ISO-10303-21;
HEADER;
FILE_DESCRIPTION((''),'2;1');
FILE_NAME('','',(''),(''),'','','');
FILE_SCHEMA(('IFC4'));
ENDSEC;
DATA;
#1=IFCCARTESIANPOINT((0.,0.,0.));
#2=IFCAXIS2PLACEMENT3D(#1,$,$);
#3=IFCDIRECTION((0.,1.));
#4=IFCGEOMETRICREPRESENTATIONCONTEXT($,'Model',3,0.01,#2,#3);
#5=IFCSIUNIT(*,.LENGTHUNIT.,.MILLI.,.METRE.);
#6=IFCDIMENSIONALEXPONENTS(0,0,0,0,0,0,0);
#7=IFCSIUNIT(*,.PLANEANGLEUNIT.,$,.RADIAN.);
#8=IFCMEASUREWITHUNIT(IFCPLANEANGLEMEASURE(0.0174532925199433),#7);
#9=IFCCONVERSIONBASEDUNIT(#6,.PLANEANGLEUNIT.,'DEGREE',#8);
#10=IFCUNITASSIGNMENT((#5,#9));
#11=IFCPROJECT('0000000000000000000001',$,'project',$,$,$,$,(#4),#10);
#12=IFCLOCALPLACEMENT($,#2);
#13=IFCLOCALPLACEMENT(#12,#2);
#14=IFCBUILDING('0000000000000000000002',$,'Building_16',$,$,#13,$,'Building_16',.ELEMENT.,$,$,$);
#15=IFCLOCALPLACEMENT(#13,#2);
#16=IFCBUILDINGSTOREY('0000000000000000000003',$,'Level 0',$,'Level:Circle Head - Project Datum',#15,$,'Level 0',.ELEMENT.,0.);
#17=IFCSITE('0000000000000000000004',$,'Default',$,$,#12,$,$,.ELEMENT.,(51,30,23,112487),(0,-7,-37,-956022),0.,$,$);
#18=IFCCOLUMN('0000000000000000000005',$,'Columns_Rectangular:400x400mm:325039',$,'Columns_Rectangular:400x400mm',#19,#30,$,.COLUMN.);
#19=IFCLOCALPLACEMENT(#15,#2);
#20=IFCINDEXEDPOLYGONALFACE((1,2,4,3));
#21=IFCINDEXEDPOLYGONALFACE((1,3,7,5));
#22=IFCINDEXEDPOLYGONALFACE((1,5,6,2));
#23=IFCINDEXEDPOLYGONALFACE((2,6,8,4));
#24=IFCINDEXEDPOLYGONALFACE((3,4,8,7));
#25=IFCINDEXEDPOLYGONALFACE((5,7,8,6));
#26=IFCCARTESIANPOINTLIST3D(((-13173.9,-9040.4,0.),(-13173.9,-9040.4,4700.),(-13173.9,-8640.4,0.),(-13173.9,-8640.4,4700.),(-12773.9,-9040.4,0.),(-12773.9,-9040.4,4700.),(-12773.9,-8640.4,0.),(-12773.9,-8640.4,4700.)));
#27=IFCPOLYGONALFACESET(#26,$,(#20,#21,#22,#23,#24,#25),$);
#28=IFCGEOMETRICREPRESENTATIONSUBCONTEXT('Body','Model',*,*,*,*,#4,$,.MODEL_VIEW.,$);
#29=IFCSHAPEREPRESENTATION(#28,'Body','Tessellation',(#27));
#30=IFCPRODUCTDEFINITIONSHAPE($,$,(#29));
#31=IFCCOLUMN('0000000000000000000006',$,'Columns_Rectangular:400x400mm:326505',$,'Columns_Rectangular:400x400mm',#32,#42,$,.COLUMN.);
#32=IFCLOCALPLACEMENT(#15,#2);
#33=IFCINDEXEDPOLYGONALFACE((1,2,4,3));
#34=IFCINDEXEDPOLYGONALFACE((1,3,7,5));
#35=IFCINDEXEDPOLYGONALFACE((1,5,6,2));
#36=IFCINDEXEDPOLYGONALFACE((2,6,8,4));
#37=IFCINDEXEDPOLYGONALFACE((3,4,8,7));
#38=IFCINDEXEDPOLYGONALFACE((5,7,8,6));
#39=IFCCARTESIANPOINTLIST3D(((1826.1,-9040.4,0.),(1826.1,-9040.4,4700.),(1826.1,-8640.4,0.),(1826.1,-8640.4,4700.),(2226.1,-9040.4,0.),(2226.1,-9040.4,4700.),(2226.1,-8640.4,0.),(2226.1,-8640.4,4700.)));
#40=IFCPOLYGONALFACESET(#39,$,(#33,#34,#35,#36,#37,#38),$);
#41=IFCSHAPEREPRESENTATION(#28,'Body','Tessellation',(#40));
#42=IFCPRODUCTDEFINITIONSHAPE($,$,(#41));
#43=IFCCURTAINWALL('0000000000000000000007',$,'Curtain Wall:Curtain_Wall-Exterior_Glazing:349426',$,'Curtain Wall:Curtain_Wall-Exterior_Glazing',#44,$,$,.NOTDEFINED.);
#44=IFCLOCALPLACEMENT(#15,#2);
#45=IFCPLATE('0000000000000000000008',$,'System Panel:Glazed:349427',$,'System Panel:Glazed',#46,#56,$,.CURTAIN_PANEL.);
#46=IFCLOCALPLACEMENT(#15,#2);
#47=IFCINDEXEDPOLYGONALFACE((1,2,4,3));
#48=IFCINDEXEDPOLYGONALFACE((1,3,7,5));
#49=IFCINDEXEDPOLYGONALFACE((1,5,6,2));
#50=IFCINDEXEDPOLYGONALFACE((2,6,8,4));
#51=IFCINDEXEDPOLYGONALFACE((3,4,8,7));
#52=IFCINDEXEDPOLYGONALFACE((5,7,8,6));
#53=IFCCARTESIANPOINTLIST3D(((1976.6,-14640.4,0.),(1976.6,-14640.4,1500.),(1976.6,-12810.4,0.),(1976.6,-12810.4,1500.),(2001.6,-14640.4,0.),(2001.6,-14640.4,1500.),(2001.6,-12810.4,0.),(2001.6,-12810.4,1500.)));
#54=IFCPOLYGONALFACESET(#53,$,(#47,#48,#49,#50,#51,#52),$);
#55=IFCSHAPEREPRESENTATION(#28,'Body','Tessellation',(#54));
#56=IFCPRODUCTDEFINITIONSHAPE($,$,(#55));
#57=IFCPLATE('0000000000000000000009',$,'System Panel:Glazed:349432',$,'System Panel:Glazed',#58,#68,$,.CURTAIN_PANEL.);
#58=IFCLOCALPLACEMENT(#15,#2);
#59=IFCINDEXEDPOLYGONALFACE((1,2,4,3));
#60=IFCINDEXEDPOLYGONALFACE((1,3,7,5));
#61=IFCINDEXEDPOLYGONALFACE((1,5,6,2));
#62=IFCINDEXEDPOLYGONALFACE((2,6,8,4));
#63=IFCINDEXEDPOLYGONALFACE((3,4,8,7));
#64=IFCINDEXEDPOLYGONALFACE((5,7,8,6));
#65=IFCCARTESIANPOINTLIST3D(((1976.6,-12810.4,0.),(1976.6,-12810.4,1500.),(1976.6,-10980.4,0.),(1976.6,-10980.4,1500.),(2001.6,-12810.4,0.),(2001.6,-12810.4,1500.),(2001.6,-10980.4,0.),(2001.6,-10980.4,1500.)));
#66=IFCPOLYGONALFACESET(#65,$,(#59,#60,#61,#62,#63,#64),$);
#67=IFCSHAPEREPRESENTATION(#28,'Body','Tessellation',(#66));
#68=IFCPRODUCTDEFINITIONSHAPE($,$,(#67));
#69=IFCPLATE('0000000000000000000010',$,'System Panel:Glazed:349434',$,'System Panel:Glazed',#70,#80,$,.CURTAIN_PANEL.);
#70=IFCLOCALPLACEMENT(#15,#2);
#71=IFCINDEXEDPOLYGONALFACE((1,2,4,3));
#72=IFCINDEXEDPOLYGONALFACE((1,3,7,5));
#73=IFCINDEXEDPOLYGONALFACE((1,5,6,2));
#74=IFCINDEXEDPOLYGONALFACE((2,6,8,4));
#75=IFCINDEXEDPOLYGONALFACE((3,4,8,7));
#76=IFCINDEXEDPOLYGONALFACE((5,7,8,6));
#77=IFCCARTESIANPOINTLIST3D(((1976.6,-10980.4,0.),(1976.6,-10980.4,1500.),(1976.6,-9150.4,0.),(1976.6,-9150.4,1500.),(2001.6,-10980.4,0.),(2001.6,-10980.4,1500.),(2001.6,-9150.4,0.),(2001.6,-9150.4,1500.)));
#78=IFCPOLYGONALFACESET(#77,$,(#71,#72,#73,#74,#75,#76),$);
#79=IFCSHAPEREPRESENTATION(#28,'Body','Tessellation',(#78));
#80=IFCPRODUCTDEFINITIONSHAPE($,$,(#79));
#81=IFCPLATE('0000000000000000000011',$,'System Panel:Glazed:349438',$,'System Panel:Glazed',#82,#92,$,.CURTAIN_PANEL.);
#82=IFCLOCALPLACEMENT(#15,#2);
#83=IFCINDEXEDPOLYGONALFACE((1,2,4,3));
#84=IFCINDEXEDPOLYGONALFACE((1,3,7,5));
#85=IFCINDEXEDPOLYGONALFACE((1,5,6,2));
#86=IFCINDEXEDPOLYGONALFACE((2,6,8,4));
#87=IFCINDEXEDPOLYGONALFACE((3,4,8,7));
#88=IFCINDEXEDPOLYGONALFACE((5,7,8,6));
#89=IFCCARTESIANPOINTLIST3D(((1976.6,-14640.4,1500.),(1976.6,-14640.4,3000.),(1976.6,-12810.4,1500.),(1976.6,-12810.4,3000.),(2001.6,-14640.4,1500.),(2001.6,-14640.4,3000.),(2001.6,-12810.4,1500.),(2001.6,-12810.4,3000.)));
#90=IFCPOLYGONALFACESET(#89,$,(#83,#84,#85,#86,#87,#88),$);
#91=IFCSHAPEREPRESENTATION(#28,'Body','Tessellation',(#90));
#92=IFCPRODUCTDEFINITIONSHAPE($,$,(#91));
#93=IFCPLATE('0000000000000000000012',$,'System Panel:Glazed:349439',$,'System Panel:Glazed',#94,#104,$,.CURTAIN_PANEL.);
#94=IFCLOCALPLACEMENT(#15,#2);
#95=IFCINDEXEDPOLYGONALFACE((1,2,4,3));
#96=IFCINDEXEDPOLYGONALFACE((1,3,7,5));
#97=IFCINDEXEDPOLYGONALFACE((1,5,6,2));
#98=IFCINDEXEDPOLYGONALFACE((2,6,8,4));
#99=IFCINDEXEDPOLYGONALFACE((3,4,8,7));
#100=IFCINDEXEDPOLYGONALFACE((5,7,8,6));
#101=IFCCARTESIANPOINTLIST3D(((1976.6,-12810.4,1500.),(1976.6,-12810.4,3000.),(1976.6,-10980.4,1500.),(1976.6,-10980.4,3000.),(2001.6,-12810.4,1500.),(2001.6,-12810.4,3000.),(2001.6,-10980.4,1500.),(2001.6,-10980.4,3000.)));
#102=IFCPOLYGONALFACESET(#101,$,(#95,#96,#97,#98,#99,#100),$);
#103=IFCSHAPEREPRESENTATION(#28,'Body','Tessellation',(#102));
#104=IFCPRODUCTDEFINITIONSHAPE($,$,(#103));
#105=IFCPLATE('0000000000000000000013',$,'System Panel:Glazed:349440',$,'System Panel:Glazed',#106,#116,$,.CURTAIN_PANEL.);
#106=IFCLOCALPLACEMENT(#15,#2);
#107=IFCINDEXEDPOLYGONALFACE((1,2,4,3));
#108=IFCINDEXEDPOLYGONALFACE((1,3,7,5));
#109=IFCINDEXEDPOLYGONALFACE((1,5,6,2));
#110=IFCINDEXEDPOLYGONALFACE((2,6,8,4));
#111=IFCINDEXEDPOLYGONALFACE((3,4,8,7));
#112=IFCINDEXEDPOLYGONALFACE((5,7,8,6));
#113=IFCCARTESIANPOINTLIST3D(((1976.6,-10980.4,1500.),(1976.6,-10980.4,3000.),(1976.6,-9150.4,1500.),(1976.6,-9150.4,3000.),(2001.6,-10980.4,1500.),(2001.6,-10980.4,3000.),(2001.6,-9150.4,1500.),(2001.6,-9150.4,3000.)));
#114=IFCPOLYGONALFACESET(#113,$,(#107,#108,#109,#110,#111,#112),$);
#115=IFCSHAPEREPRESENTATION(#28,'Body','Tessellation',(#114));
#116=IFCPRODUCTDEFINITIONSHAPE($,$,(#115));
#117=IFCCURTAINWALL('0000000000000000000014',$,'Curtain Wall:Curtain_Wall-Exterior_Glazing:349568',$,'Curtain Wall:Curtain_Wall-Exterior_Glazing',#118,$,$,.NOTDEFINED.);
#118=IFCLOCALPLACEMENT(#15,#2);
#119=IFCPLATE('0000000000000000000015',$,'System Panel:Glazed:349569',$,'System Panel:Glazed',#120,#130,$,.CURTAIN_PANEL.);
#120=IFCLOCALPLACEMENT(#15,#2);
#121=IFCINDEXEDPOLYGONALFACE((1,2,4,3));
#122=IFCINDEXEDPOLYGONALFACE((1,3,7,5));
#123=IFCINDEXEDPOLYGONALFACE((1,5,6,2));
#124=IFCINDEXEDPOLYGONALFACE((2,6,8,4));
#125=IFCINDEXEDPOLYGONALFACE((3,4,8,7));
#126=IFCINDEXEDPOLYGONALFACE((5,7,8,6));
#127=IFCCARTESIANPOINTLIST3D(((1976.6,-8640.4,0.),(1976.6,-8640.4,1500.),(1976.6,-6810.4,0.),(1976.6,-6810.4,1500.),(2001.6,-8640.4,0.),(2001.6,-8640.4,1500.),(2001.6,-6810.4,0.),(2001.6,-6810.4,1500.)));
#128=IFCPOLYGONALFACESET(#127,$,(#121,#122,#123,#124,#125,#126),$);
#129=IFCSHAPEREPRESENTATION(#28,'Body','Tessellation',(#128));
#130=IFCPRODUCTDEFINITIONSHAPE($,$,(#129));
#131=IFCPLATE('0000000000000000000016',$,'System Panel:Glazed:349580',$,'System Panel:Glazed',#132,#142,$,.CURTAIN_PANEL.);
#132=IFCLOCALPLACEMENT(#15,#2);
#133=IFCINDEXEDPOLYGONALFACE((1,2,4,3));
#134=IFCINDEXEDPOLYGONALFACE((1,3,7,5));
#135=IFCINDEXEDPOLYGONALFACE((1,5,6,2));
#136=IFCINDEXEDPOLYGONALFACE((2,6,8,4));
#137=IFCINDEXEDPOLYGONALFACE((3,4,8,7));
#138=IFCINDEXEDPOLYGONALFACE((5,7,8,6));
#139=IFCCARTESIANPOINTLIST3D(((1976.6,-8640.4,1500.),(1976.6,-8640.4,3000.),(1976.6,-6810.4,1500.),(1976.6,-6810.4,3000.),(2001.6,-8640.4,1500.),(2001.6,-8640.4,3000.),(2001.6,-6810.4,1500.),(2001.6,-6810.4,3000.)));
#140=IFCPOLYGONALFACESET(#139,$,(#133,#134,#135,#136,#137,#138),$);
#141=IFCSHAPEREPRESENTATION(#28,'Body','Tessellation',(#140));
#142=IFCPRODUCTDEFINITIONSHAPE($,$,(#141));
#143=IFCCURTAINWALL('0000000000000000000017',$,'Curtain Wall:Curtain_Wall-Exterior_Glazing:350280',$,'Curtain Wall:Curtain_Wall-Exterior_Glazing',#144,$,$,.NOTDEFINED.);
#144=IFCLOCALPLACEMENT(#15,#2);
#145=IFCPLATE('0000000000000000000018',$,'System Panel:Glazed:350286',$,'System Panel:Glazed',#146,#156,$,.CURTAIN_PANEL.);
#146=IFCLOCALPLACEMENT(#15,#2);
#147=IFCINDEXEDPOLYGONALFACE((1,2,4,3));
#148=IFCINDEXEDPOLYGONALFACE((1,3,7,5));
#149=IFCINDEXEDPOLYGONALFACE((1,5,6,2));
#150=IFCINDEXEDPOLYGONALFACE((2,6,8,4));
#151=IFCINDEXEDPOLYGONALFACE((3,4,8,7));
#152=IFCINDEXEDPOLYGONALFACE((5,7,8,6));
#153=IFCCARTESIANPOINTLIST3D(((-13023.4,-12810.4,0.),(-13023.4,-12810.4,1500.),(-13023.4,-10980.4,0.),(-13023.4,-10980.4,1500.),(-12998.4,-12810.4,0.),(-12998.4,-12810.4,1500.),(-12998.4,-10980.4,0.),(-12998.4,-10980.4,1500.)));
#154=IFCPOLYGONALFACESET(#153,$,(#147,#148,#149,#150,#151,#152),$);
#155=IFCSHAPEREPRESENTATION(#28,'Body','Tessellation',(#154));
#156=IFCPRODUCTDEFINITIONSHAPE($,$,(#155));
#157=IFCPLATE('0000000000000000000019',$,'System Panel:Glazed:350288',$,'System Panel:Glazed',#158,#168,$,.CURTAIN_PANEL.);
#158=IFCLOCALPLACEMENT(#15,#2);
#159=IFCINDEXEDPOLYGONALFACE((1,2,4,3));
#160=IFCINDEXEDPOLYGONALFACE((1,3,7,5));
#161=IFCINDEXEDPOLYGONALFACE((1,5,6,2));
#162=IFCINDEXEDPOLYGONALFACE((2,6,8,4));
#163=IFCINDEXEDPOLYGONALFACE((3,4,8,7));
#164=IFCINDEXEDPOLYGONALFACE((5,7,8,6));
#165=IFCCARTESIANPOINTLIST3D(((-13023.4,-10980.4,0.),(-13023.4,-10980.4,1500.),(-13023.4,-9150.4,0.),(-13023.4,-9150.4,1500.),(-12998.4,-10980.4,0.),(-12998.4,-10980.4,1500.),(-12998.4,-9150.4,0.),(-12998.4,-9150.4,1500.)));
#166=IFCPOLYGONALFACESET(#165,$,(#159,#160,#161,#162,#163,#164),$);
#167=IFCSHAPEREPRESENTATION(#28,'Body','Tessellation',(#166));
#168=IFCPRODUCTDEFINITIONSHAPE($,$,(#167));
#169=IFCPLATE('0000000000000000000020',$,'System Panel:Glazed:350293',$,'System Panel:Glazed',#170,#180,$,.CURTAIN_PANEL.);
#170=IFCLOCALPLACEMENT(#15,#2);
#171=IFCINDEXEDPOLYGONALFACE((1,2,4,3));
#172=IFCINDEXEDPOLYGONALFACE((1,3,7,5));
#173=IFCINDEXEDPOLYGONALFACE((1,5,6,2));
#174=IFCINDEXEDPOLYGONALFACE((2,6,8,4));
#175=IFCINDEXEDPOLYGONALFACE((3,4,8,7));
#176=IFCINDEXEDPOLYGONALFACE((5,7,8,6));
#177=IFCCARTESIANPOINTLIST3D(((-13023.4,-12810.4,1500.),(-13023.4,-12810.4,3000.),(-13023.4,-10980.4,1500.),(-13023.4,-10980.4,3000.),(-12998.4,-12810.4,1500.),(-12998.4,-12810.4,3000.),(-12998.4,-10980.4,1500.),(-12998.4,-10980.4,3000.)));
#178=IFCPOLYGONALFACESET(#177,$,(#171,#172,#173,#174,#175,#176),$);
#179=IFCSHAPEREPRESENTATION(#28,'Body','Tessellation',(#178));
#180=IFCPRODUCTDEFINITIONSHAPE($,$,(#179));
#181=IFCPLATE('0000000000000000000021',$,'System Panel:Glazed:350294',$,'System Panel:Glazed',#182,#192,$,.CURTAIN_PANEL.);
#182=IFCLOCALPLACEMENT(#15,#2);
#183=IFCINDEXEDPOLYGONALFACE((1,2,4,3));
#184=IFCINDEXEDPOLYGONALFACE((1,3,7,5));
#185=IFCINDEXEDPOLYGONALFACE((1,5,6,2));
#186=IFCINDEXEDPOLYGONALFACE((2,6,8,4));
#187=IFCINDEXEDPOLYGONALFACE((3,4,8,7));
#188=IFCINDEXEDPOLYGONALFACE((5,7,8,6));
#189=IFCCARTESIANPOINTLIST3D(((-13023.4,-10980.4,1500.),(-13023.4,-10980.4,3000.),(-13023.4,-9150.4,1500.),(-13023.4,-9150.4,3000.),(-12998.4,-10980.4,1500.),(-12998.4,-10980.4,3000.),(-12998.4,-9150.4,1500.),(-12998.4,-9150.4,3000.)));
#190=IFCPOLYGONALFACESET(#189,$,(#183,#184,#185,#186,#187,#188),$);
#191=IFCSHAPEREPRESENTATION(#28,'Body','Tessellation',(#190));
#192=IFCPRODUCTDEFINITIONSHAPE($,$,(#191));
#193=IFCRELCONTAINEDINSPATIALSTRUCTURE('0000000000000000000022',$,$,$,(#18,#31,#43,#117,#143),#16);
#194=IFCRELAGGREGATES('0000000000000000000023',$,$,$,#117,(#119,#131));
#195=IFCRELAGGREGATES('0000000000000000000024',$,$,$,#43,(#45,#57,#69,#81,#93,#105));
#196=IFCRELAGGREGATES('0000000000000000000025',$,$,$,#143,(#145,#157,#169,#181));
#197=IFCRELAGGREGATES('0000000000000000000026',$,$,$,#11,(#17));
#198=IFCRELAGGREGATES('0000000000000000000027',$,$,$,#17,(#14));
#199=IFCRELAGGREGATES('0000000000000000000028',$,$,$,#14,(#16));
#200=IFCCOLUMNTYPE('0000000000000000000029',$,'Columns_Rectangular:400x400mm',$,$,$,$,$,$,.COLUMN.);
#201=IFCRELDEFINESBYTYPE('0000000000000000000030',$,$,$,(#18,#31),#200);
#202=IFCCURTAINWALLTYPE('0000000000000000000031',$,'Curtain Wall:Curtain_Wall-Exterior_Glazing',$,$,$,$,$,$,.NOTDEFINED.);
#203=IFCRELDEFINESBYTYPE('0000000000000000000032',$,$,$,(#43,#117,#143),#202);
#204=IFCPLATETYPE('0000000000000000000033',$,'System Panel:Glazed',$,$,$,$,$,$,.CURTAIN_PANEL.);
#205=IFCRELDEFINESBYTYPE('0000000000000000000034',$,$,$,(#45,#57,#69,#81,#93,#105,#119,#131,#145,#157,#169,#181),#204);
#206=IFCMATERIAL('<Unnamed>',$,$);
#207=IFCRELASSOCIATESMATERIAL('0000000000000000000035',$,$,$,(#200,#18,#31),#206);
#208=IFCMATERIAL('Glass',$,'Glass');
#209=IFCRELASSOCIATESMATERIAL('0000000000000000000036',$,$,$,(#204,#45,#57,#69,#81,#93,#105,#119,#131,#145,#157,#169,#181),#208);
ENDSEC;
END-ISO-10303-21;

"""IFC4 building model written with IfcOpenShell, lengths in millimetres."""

from ifc_helpers import new_model, entity, si_unit, converted_unit, direction, frame, origin, place, context, subcontext, project, spatial, indexed_curve, outline, extrude, source, transform, mapped, material, type_object, type_shapes, element, aggregate, save


model = new_model("IFC4")

# Units and contexts
model_context = context("Model", 3, precision=0.01, world=origin(), true_north=direction((0.0, 1.0)))
body_context = subcontext(model_context, "Body", "Model", "MODEL_VIEW")
ifc_project = project(units=[si_unit("LENGTHUNIT", "METRE", prefix="MILLI"), converted_unit("PLANEANGLEUNIT", "DEGREE", entity("IfcPlaneAngleMeasure", 0.0174532925199433), si_unit("PLANEANGLEUNIT", "RADIAN"), dimensions=[0, 0, 0, 0, 0, 0, 0])], contexts=[model_context])

# Site, building, storey
site_placement = place(None, origin())
site = spatial("IfcSite", under=ifc_project, at=site_placement, Name="Default", CompositionType="ELEMENT", RefLatitude=(51, 30, 23, 112487), RefLongitude=(0, -7, -37, -956022), RefElevation=0.0)
building_placement = place(site_placement, origin())
building = spatial("IfcBuilding", under=site, at=building_placement, Name="Building_16", LongName="Building_16", CompositionType="ELEMENT")
storey_placement = place(building_placement, origin())
storey = spatial("IfcBuildingStorey", under=building, at=storey_placement, Name="Level 0", ObjectType="Level:Circle Head - Project Datum", LongName="Level 0", CompositionType="ELEMENT", Elevation=0.0)

# Columns
ifc_material_1 = material(Name="<Unnamed>")
column_type = type_object("IfcColumnType", Name="Columns_Rectangular:400x400mm", PredefinedType="COLUMN", material=ifc_material_1)
shared_shape_1 = source(origin(), body_context, "Body", "SweptSolid", [
    extrude(outline(indexed_curve([(-200.0, -200.0), (200.0, -200.0), (200.0, 200.0), (-200.0, 200.0), (-200.0, -200.0)], self_intersect=False)), frame((0.0, 0.0, 0.0), z_axis=(0.0, 0.0, 1.0), x_axis=(-1.0, 0.0, 0.0)), (0.0, 0.0, 1.0), 4700.0),
])
type_shapes(column_type, [shared_shape_1])
for number, where, name in (
    (1, (-12973.9, -8840.4, 0.0), "Columns_Rectangular:400x400mm:325039"),
    (2, (2026.1, -8840.4, 0.0), "Columns_Rectangular:400x400mm:326505"),
):
    element("IfcColumn", number, at=place(storey_placement, frame(where)), inside=storey, type_object=column_type, material=ifc_material_1, Name=name, ObjectType="Columns_Rectangular:400x400mm", PredefinedType="COLUMN", context=body_context, shape_type="MappedRepresentation", body=[
        mapped(shared_shape_1, transform((0.0, 0.0, 0.0), scale=1.0)),
    ])

# Curtain walls, plates
curtain_wall_type = type_object("IfcCurtainWallType", Name="Curtain Wall:Curtain_Wall-Exterior_Glazing", PredefinedType="NOTDEFINED")
curtain_wall_1_placement = place(storey_placement, origin())
curtain_wall_1 = element("IfcCurtainWall", 3, at=curtain_wall_1_placement, inside=storey, type_object=curtain_wall_type, Name="Curtain Wall:Curtain_Wall-Exterior_Glazing:349426", ObjectType="Curtain Wall:Curtain_Wall-Exterior_Glazing", PredefinedType="NOTDEFINED")
ifc_material_2 = material(Name="Glass", Category="Glass")
plate_type_1 = type_object("IfcPlateType", Name="System Panel:Glazed", PredefinedType="CURTAIN_PANEL", material=ifc_material_2)
shared_shape_2 = source(origin(), body_context, "Body", "SweptSolid", [
    extrude(outline(indexed_curve([(-12.5, -915.0), (12.5, -915.0), (12.5, 915.0), (-12.5, 915.0), (-12.5, -915.0)], self_intersect=False)), frame((0.0, 37.0, 0.0), z_axis=(0.0, 0.0, 1.0), x_axis=(0.0, 1.0, 0.0)), (0.0, 0.0, 1.0), 1500.0),
])
type_shapes(plate_type_1, [shared_shape_2])
plate_1_placement = place(curtain_wall_1_placement, frame((2026.1, -13725.4, 0.0), z_axis=(0.0, 0.0, 1.0), x_axis=(0.0, 1.0, 0.0)))
plate_1 = element("IfcPlate", 4, at=plate_1_placement, type_object=plate_type_1, material=ifc_material_2, Name="System Panel:Glazed:349427", ObjectType="System Panel:Glazed", PredefinedType="CURTAIN_PANEL", context=body_context, shape_type="MappedRepresentation", body=[
    mapped(shared_shape_2, transform((0.0, 0.0, 0.0), scale=1.0)),
])
plate_2_placement = place(curtain_wall_1_placement, frame((2026.1, -11895.4, 0.0), z_axis=(0.0, 0.0, 1.0), x_axis=(0.0, 1.0, 0.0)))
plate_2 = element("IfcPlate", 5, at=plate_2_placement, type_object=plate_type_1, material=ifc_material_2, Name="System Panel:Glazed:349432", ObjectType="System Panel:Glazed", PredefinedType="CURTAIN_PANEL", context=body_context, shape_type="MappedRepresentation", body=[
    mapped(shared_shape_2, transform((0.0, 0.0, 0.0), scale=1.0)),
])
plate_3_placement = place(curtain_wall_1_placement, frame((2026.1, -10065.4, 0.0), z_axis=(0.0, 0.0, 1.0), x_axis=(0.0, 1.0, 0.0)))
plate_3 = element("IfcPlate", 6, at=plate_3_placement, type_object=plate_type_1, material=ifc_material_2, Name="System Panel:Glazed:349434", ObjectType="System Panel:Glazed", PredefinedType="CURTAIN_PANEL", context=body_context, shape_type="MappedRepresentation", body=[
    mapped(shared_shape_2, transform((0.0, 0.0, 0.0), scale=1.0)),
])
plate_4_placement = place(curtain_wall_1_placement, frame((2026.1, -13725.4, 1500.0), z_axis=(0.0, 0.0, 1.0), x_axis=(0.0, 1.0, 0.0)))
plate_4 = element("IfcPlate", 7, at=plate_4_placement, type_object=plate_type_1, material=ifc_material_2, Name="System Panel:Glazed:349438", ObjectType="System Panel:Glazed", PredefinedType="CURTAIN_PANEL", context=body_context, shape_type="MappedRepresentation", body=[
    mapped(shared_shape_2, transform((0.0, 0.0, 0.0), scale=1.0)),
])
plate_5_placement = place(curtain_wall_1_placement, frame((2026.1, -11895.4, 1500.0), z_axis=(0.0, 0.0, 1.0), x_axis=(0.0, 1.0, 0.0)))
plate_5 = element("IfcPlate", 8, at=plate_5_placement, type_object=plate_type_1, material=ifc_material_2, Name="System Panel:Glazed:349439", ObjectType="System Panel:Glazed", PredefinedType="CURTAIN_PANEL", context=body_context, shape_type="MappedRepresentation", body=[
    mapped(shared_shape_2, transform((0.0, 0.0, 0.0), scale=1.0)),
])
plate_6_placement = place(curtain_wall_1_placement, frame((2026.1, -10065.4, 1500.0), z_axis=(0.0, 0.0, 1.0), x_axis=(0.0, 1.0, 0.0)))
plate_6 = element("IfcPlate", 9, at=plate_6_placement, type_object=plate_type_1, material=ifc_material_2, Name="System Panel:Glazed:349440", ObjectType="System Panel:Glazed", PredefinedType="CURTAIN_PANEL", context=body_context, shape_type="MappedRepresentation", body=[
    mapped(shared_shape_2, transform((0.0, 0.0, 0.0), scale=1.0)),
])
curtain_wall_2_placement = place(storey_placement, origin())
curtain_wall_2 = element("IfcCurtainWall", 10, at=curtain_wall_2_placement, inside=storey, type_object=curtain_wall_type, Name="Curtain Wall:Curtain_Wall-Exterior_Glazing:349568", ObjectType="Curtain Wall:Curtain_Wall-Exterior_Glazing", PredefinedType="NOTDEFINED")
plate_7_placement = place(curtain_wall_2_placement, frame((2026.1, -7725.4, 0.0), z_axis=(0.0, 0.0, 1.0), x_axis=(0.0, 1.0, 0.0)))
plate_7 = element("IfcPlate", 11, at=plate_7_placement, type_object=plate_type_1, material=ifc_material_2, Name="System Panel:Glazed:349569", ObjectType="System Panel:Glazed", PredefinedType="CURTAIN_PANEL", context=body_context, shape_type="MappedRepresentation", body=[
    mapped(shared_shape_2, transform((0.0, 0.0, 0.0), scale=1.0)),
])
plate_8_placement = place(curtain_wall_2_placement, frame((2026.1, -7725.4, 1500.0), z_axis=(0.0, 0.0, 1.0), x_axis=(0.0, 1.0, 0.0)))
plate_8 = element("IfcPlate", 12, at=plate_8_placement, type_object=plate_type_1, material=ifc_material_2, Name="System Panel:Glazed:349580", ObjectType="System Panel:Glazed", PredefinedType="CURTAIN_PANEL", context=body_context, shape_type="MappedRepresentation", body=[
    mapped(shared_shape_2, transform((0.0, 0.0, 0.0), scale=1.0)),
])
aggregate(curtain_wall_2, [plate_7, plate_8])
curtain_wall_3_placement = place(storey_placement, origin())
curtain_wall_3 = element("IfcCurtainWall", 13, at=curtain_wall_3_placement, inside=storey, type_object=curtain_wall_type, Name="Curtain Wall:Curtain_Wall-Exterior_Glazing:350280", ObjectType="Curtain Wall:Curtain_Wall-Exterior_Glazing", PredefinedType="NOTDEFINED")
plate_9_placement = place(curtain_wall_3_placement, frame((-12973.9, -11895.4, 0.0), z_axis=(0.0, 0.0, 1.0), x_axis=(0.0, 1.0, 0.0)))
plate_9 = element("IfcPlate", 14, at=plate_9_placement, type_object=plate_type_1, material=ifc_material_2, Name="System Panel:Glazed:350286", ObjectType="System Panel:Glazed", PredefinedType="CURTAIN_PANEL", context=body_context, shape_type="MappedRepresentation", body=[
    mapped(shared_shape_2, transform((0.0, 0.0, 0.0), scale=1.0)),
])
plate_10_placement = place(curtain_wall_3_placement, frame((-12973.9, -10065.4, 0.0), z_axis=(0.0, 0.0, 1.0), x_axis=(0.0, 1.0, 0.0)))
plate_10 = element("IfcPlate", 15, at=plate_10_placement, type_object=plate_type_1, material=ifc_material_2, Name="System Panel:Glazed:350288", ObjectType="System Panel:Glazed", PredefinedType="CURTAIN_PANEL", context=body_context, shape_type="MappedRepresentation", body=[
    mapped(shared_shape_2, transform((0.0, 0.0, 0.0), scale=1.0)),
])
plate_11_placement = place(curtain_wall_3_placement, frame((-12973.9, -11895.4, 1500.0), z_axis=(0.0, 0.0, 1.0), x_axis=(0.0, 1.0, 0.0)))
plate_11 = element("IfcPlate", 16, at=plate_11_placement, type_object=plate_type_1, material=ifc_material_2, Name="System Panel:Glazed:350293", ObjectType="System Panel:Glazed", PredefinedType="CURTAIN_PANEL", context=body_context, shape_type="MappedRepresentation", body=[
    mapped(shared_shape_2, transform((0.0, 0.0, 0.0), scale=1.0)),
])
plate_12_placement = place(curtain_wall_3_placement, frame((-12973.9, -10065.4, 1500.0), z_axis=(0.0, 0.0, 1.0), x_axis=(0.0, 1.0, 0.0)))
plate_12 = element("IfcPlate", 17, at=plate_12_placement, type_object=plate_type_1, material=ifc_material_2, Name="System Panel:Glazed:350294", ObjectType="System Panel:Glazed", PredefinedType="CURTAIN_PANEL", context=body_context, shape_type="MappedRepresentation", body=[
    mapped(shared_shape_2, transform((0.0, 0.0, 0.0), scale=1.0)),
])

aggregate(curtain_wall_1, [plate_1, plate_2, plate_3, plate_4, plate_5, plate_6])
aggregate(curtain_wall_3, [plate_9, plate_10, plate_11, plate_12])

save(model, "model.ifc")
